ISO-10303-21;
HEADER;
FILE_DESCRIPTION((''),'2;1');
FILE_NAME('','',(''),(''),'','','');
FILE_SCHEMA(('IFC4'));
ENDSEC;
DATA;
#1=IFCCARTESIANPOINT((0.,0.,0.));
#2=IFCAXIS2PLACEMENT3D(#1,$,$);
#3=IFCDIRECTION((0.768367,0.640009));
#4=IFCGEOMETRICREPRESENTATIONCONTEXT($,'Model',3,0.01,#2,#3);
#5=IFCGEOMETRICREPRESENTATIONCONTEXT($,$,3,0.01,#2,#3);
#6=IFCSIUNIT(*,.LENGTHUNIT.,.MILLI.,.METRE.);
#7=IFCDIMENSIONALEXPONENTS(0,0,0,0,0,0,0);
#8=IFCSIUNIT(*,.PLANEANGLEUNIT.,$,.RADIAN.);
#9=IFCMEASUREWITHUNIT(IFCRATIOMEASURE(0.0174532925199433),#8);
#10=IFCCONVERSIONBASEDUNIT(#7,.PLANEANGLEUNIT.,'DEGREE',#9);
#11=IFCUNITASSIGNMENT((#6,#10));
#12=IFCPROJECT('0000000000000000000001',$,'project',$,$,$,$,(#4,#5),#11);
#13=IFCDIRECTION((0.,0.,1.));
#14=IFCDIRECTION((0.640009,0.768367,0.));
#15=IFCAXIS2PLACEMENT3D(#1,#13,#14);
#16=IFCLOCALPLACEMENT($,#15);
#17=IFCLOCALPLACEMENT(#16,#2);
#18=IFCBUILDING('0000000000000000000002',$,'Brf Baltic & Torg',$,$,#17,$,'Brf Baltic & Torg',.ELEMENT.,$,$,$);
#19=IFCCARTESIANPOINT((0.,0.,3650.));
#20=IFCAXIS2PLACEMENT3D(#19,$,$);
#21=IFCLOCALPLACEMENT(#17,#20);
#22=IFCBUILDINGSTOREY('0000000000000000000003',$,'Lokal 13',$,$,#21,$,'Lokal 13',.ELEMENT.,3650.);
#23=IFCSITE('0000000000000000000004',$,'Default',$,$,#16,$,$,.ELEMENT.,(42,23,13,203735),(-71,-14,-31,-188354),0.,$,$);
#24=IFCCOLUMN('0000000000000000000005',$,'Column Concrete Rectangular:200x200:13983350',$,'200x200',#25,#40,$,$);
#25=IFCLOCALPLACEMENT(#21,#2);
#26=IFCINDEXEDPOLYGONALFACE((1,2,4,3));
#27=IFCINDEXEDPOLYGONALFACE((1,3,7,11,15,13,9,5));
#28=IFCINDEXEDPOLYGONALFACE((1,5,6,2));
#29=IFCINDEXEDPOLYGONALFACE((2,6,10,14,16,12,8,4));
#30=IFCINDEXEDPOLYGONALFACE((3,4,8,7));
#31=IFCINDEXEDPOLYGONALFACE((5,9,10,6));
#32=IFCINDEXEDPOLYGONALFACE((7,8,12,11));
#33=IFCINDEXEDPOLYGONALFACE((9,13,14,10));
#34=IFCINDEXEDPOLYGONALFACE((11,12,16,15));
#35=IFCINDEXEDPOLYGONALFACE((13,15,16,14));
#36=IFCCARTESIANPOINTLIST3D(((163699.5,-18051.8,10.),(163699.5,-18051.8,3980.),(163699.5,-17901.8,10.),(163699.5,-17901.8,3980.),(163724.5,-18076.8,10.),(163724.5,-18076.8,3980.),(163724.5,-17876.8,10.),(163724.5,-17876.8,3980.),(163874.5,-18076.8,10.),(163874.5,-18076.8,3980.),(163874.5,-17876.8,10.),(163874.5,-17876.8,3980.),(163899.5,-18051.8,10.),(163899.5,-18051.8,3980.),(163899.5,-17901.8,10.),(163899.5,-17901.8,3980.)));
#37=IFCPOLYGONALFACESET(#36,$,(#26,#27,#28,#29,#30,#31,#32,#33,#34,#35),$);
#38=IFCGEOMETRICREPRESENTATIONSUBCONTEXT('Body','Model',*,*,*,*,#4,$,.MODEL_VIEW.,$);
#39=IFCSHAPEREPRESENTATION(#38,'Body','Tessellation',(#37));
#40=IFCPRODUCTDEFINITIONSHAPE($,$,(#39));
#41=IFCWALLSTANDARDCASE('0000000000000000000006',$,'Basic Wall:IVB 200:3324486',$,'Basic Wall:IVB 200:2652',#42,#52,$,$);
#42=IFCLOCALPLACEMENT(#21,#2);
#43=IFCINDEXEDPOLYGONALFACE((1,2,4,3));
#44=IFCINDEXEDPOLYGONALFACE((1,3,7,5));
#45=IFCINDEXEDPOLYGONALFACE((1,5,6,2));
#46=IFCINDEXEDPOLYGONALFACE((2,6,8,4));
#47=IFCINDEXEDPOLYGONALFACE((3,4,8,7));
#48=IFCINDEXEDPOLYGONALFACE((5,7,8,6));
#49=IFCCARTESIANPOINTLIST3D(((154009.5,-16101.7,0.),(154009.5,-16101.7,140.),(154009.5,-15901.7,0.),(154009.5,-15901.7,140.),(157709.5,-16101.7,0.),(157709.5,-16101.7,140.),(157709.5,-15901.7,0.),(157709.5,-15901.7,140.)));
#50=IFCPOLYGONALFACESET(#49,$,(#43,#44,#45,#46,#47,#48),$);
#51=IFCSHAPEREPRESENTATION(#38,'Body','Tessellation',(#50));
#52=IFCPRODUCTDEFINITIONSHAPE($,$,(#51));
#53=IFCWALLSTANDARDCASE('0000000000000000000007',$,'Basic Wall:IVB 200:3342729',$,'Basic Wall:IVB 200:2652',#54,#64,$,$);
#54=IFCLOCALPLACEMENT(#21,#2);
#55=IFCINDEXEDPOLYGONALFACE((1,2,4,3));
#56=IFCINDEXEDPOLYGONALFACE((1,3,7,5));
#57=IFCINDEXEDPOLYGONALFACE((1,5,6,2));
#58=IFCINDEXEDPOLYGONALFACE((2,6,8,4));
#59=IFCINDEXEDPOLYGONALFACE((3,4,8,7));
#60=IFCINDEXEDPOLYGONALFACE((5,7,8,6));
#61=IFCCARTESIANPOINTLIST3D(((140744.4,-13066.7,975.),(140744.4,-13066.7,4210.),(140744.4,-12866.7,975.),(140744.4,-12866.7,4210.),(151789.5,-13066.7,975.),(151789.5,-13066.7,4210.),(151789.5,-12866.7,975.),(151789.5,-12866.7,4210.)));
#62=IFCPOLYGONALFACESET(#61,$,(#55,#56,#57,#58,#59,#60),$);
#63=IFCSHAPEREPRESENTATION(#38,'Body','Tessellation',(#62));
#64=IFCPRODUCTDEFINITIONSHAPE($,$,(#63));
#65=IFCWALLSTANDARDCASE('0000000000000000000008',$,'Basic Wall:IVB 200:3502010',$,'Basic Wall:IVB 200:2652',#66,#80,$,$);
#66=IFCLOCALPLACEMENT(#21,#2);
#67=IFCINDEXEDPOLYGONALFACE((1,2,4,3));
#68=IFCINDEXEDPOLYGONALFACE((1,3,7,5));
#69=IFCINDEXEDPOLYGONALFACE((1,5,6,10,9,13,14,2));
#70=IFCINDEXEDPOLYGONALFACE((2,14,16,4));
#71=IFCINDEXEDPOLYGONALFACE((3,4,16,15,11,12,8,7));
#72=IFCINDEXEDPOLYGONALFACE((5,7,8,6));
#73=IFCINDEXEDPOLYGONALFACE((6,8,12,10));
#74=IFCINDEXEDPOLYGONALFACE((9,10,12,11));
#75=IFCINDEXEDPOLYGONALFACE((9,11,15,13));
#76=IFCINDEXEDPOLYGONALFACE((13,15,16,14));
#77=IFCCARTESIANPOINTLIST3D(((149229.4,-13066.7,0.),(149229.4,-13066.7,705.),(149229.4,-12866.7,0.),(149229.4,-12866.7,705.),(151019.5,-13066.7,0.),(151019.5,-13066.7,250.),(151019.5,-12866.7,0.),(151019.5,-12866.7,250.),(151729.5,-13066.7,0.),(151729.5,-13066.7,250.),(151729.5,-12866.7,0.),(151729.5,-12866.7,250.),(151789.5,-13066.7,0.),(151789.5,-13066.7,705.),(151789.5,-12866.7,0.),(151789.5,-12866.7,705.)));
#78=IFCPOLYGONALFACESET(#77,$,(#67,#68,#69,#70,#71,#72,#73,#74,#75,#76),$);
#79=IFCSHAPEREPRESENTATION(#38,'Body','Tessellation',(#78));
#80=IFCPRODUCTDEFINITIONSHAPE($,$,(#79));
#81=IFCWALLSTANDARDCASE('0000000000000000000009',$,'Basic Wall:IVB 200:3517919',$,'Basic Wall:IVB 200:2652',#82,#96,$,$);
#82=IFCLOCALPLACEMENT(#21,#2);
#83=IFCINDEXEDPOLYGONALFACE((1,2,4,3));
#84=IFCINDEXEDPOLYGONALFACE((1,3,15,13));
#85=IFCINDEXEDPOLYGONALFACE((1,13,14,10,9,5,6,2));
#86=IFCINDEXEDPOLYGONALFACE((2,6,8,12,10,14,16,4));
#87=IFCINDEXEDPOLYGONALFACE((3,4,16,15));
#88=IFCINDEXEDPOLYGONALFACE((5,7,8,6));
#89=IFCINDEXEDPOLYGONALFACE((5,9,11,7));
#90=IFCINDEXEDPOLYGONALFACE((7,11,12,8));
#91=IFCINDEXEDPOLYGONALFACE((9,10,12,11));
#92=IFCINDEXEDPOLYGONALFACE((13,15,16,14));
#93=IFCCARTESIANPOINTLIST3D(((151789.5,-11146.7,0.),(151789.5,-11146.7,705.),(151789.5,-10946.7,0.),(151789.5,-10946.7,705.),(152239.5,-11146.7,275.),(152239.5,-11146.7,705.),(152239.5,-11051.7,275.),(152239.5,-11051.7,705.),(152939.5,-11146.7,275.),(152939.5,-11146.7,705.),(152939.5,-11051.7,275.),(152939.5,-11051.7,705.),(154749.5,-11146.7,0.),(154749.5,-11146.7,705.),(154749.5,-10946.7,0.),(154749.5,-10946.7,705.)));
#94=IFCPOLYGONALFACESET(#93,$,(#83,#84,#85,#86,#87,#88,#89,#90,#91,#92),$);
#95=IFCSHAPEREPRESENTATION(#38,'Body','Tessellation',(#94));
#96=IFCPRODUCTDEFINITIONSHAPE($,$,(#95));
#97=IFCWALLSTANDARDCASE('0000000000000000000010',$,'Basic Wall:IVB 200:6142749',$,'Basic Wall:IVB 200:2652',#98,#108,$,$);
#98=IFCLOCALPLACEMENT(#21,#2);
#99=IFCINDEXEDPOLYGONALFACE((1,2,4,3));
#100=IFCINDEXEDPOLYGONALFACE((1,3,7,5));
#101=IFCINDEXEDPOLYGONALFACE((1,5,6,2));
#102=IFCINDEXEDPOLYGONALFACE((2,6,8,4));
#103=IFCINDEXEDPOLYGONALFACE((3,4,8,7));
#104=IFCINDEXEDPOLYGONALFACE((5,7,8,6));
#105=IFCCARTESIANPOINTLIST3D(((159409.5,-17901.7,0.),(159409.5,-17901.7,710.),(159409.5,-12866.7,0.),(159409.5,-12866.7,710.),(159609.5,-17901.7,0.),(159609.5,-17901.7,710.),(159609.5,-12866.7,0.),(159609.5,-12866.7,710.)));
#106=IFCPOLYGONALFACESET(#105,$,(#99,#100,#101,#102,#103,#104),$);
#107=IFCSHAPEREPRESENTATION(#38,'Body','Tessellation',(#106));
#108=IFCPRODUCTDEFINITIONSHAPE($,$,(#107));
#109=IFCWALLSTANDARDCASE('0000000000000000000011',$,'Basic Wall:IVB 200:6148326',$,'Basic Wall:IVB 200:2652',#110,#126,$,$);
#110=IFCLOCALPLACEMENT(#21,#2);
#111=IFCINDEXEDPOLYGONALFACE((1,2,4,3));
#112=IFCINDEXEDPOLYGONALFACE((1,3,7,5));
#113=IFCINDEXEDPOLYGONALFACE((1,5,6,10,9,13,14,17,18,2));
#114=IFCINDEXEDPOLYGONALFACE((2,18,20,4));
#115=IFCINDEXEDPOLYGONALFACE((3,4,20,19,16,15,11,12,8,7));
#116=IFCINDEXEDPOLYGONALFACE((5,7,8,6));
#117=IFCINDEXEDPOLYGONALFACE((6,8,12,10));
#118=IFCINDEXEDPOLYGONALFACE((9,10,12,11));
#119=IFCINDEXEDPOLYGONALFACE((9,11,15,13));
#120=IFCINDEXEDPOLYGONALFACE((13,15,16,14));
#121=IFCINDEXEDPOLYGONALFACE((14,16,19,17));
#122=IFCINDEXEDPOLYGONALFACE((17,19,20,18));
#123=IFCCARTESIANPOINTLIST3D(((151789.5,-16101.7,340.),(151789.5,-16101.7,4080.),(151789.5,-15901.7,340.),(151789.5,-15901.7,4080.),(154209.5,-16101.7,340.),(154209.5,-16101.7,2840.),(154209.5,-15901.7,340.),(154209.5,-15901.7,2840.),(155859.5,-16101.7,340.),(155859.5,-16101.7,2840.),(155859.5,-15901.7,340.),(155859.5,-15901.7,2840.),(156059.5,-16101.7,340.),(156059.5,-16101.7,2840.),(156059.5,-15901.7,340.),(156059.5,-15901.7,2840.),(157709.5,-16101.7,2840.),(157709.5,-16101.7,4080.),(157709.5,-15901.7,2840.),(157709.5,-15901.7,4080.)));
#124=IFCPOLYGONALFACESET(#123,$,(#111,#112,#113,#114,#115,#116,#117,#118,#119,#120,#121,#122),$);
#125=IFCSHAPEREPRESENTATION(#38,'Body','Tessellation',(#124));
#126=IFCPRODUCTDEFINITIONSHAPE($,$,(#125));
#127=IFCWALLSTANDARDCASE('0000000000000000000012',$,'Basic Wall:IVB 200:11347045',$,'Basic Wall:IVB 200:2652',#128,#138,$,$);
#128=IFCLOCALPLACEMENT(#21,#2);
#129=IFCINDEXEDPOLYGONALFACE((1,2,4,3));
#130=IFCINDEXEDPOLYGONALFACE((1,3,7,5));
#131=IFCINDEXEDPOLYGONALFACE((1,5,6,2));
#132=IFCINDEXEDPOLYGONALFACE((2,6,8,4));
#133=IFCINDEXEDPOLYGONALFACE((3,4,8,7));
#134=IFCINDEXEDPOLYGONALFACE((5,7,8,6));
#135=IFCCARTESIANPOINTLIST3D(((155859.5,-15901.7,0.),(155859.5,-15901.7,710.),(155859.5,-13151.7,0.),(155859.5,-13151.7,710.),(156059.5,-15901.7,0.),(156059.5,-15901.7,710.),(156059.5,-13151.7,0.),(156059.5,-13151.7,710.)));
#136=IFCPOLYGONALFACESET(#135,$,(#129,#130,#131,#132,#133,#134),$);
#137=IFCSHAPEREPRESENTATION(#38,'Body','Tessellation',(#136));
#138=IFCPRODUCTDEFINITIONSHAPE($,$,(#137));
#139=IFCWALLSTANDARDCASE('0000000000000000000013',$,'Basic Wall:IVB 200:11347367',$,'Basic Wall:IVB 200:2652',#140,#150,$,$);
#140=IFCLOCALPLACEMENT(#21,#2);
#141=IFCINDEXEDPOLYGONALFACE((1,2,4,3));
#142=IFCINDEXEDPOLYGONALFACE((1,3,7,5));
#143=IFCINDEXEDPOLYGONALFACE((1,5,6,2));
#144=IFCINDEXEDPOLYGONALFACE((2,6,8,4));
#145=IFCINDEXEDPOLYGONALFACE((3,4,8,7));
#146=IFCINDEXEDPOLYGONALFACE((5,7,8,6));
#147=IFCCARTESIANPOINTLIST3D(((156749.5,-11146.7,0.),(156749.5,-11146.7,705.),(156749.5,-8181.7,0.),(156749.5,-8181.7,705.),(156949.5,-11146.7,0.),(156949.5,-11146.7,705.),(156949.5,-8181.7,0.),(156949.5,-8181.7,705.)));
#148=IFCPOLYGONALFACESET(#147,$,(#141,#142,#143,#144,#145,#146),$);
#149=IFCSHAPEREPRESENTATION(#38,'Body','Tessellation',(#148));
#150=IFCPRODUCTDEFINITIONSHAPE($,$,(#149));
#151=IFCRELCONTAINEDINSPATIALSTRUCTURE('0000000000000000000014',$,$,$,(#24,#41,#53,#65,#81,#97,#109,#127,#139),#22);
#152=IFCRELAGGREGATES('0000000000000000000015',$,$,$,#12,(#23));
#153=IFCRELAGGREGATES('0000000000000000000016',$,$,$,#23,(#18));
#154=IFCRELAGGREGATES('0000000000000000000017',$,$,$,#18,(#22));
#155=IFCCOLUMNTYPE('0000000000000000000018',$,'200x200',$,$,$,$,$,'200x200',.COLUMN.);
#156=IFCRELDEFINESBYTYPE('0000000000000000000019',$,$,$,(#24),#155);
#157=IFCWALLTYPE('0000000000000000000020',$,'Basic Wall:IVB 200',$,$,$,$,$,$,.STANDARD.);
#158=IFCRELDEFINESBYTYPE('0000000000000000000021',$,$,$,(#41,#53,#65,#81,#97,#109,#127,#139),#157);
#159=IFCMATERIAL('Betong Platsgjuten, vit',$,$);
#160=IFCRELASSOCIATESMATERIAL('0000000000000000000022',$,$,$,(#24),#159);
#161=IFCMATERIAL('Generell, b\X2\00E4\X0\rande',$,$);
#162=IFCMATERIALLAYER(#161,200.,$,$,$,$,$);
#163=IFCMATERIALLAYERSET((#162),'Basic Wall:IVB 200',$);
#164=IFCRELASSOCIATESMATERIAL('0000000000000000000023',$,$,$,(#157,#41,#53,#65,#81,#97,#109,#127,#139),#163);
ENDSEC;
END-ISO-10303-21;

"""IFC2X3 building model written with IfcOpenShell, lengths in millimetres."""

from ifc_helpers import new_model, entity, si_unit, converted_unit, direction, frame, frame_2d, origin, place, context, subcontext, project, spatial, polyline, rectangle, outline, extrude, clip, halfspace, bounded_halfspace, source, transform, mapped, material, layer, layer_set, layer_usage, type_object, type_shapes, element, save


model = new_model("IFC2X3")

# Units and contexts
model_context = context("Model", 3, precision=0.01, world=origin(), true_north=direction((0.768367, 0.640009)))
context_of_model = context(None, 3, precision=0.01, world=origin(), true_north=direction((0.768367, 0.640009)))
body_context = subcontext(model_context, "Body", "Model", "MODEL_VIEW")
ifc_project = project(units=[si_unit("LENGTHUNIT", "METRE", prefix="MILLI"), converted_unit("PLANEANGLEUNIT", "DEGREE", entity("IfcRatioMeasure", 0.0174532925199433), si_unit("PLANEANGLEUNIT", "RADIAN"), dimensions=[0, 0, 0, 0, 0, 0, 0])], contexts=[model_context, context_of_model])

# Site, building, storey
site_placement = place(None, frame((0.0, 0.0, 0.0), z_axis=(0.0, 0.0, 1.0), x_axis=(0.640009, 0.768367, 0.0)))
site = spatial("IfcSite", under=ifc_project, at=site_placement, Name="Default", CompositionType="ELEMENT", RefLatitude=(42, 23, 13, 203735), RefLongitude=(-71, -14, -31, -188354), RefElevation=0.0)
building_placement = place(site_placement, origin())
building = spatial("IfcBuilding", under=site, at=building_placement, Name="Brf Baltic & Torg", LongName="Brf Baltic & Torg", CompositionType="ELEMENT")
storey_placement = place(building_placement, frame((0.0, 0.0, 3650.0)))
storey = spatial("IfcBuildingStorey", under=building, at=storey_placement, Name="Lokal 13", LongName="Lokal 13", CompositionType="ELEMENT", Elevation=3650.0)

# Column
ifc_material_1 = material(Name="Betong Platsgjuten, vit")
column_type = type_object("IfcColumnType", Name="200x200", ElementType="200x200", PredefinedType="COLUMN")
shared_shape = source(origin(), body_context, "Body", "SweptSolid", [
    extrude(outline(polyline([(-75.0, -100.0), (75.0, -100.0), (100.0, -75.0), (100.0, 75.0), (75.0, 100.0), (-75.0, 100.0), (-100.0, 75.0), (-100.0, -75.0), (-75.0, -100.0)])), frame((0.0, 0.0, 3660.0), z_axis=(0.0, 0.0, 1.0), x_axis=(0.0, -1.0, 0.0)), (0.0, 0.0, 1.0), 3970.0),
])
type_shapes(column_type, [shared_shape])
column_placement = place(storey_placement, frame((163799.5, -17976.8, -3650.0)))
element("IfcColumn", 1, at=column_placement, inside=storey, type_object=column_type, material=ifc_material_1, Name="Column Concrete Rectangular:200x200:13983350", ObjectType="200x200", context=body_context, shape_type="MappedRepresentation", body=[
    mapped(shared_shape, transform((0.0, 0.0, 0.0), scale=1.0)),
])

# Wall
ifc_material_2 = material(Name="Generell, bärande")
ifc_layer = layer(ifc_material_2, 200.0)
ifc_layer_set = layer_set([ifc_layer], Name="Basic Wall:IVB 200")
ifc_layer_usage_1 = layer_usage(ifc_layer_set, "AXIS2", "NEGATIVE", 100.0)
wall_type = type_object("IfcWallType", Name="Basic Wall:IVB 200", PredefinedType="STANDARD", material=ifc_layer_set)
wall_1_placement = place(storey_placement, frame((157709.5, -16001.7, 0.0), z_axis=(0.0, 0.0, 1.0), x_axis=(-1.0, 0.0, 0.0)))
element("IfcWallStandardCase", 2, at=wall_1_placement, inside=storey, type_object=wall_type, material=ifc_layer_usage_1, Name="Basic Wall:IVB 200:3324486", ObjectType="Basic Wall:IVB 200:2652", context=body_context, shape_type="Clipping", body=[
    clip(clip(extrude(rectangle(XDim=3700.0, YDim=200.0, at=frame_2d((1850.0, 0.0), x_axis=(-1.0, 0.0))), origin(), (0.0, 0.0, 1.0), 140.0), bounded_halfspace(frame((0.0, -100.0, 140.0), z_axis=(0.0, 0.0, -1.0), x_axis=(0.0, -1.0, 0.0)), True, frame((0.0, -100.0, 140.0)), polyline([(0.0, 0.0), (3700.0, 0.0), (3700.0, 200.0), (0.0, 200.0), (0.0, 0.0)]))), halfspace(frame((0.0, 0.0, -2000.0)), True)),
])

# Wall
ifc_layer_usage_2 = layer_usage(ifc_layer_set, "AXIS2", "NEGATIVE", 100.0)
wall_2_placement = place(storey_placement, frame((151789.5, -12966.7, 975.0), z_axis=(0.0, 0.0, 1.0), x_axis=(-1.0, 0.0, 0.0)))
element("IfcWallStandardCase", 3, at=wall_2_placement, inside=storey, type_object=wall_type, material=ifc_layer_usage_2, Name="Basic Wall:IVB 200:3342729", ObjectType="Basic Wall:IVB 200:2652", context=body_context, shape_type="SweptSolid", body=[
    extrude(rectangle(XDim=11045.1, YDim=200.0, at=frame_2d((5522.5, 0.0), x_axis=(-1.0, 0.0))), origin(), (0.0, 0.0, 1.0), 3235.0),
])

# Walls, openings
ifc_layer_usage_3 = layer_usage(ifc_layer_set, "AXIS2", "NEGATIVE", 100.0)
wall_3_placement = place(storey_placement, frame((151789.5, -12966.7, 0.0), z_axis=(0.0, 0.0, 1.0), x_axis=(-1.0, 0.0, 0.0)))
wall_3 = element("IfcWallStandardCase", 4, at=wall_3_placement, inside=storey, type_object=wall_type, material=ifc_layer_usage_3, Name="Basic Wall:IVB 200:3502010", ObjectType="Basic Wall:IVB 200:2652", context=body_context, shape_type="Clipping", body=[
    clip(clip(extrude(rectangle(XDim=2560.1, YDim=200.0, at=frame_2d((1280.0, 0.0), x_axis=(-1.0, 0.0))), origin(), (0.0, 0.0, 1.0), 705.0), bounded_halfspace(frame((0.0, -100.0, 705.0), z_axis=(0.0, 0.0, -1.0), x_axis=(0.0, -1.0, 0.0)), True, frame((0.0, -100.0, 705.0)), polyline([(0.0, 0.0), (2560.1, 0.0), (2560.1, 200.0), (0.0, 200.0), (0.0, 0.0)]))), halfspace(frame((0.0, 0.0, -2000.0)), True)),
])
opening_1_placement = place(wall_3_placement, frame((151789.5, -12966.7, -2000.0), z_axis=(0.0, 0.0, 1.0), x_axis=(-1.0, 0.0, 0.0)))
element("IfcOpeningElement", 5, at=opening_1_placement, cuts=wall_3, ObjectType="Opening", context=body_context, shape_type="SweptSolid", body=[
    extrude(rectangle(XDim=910.0, YDim=710.0, at=frame_2d((0.0, 0.0), x_axis=(0.0, 1.0))), frame((151374.5, -11542.7, 1795.0), z_axis=(0.0, -1.0, 0.0), x_axis=(1.0, 0.0, 0.0)), (0.0, 0.0, 1.0), 3048.0),
])
ifc_layer_usage_4 = layer_usage(ifc_layer_set, "AXIS2", "NEGATIVE", 100.0)
wall_4_placement = place(storey_placement, frame((151789.5, -11046.7, 0.0)))
wall_4 = element("IfcWallStandardCase", 6, at=wall_4_placement, inside=storey, type_object=wall_type, material=ifc_layer_usage_4, Name="Basic Wall:IVB 200:3517919", ObjectType="Basic Wall:IVB 200:2652", context=body_context, shape_type="Clipping", body=[
    clip(clip(extrude(rectangle(XDim=2960.0, YDim=200.0, at=frame_2d((1480.0, 0.0), x_axis=(-1.0, 0.0))), origin(), (0.0, 0.0, 1.0), 705.0), bounded_halfspace(frame((0.0, 100.0, 705.0), z_axis=(0.0, 0.0, -1.0), x_axis=(0.0, 1.0, 0.0)), True, frame((0.0, 100.0, 705.0)), polyline([(0.0, 0.0), (0.0, -200.0), (200.0, -200.0), (450.0, -200.0), (450.0, -105.0), (950.0, -105.0), (950.0, 0.0), (760.0, 0.0), (0.0, 0.0)]))), halfspace(frame((0.0, 0.0, -2000.0)), True)),
])
opening_2_placement = place(wall_4_placement, origin())
element("IfcOpeningElement", 7, at=opening_2_placement, cuts=wall_4, ObjectType="Recess", context=body_context, shape_type="SweptSolid", body=[
    extrude(rectangle(XDim=430.0, YDim=700.0, at=frame_2d((0.0, 0.0), x_axis=(1.0, 0.0))), frame((800.0, -100.0, 490.0), z_axis=(0.0, 1.0, 0.0), x_axis=(0.0, 0.0, -1.0)), (0.0, 0.0, 1.0), 95.0),
])

# Wall
ifc_layer_usage_5 = layer_usage(ifc_layer_set, "AXIS2", "POSITIVE", -100.0)
wall_5_placement = place(storey_placement, frame((159509.5, -12866.7, 0.0), z_axis=(0.0, 0.0, 1.0), x_axis=(0.0, -1.0, 0.0)))
element("IfcWallStandardCase", 8, at=wall_5_placement, inside=storey, type_object=wall_type, material=ifc_layer_usage_5, Name="Basic Wall:IVB 200:6142749", ObjectType="Basic Wall:IVB 200:2652", context=body_context, shape_type="Clipping", body=[
    clip(extrude(rectangle(XDim=5035.0, YDim=200.0, at=frame_2d((2517.5, 0.0), x_axis=(-1.0, 0.0))), origin(), (0.0, 0.0, 1.0), 710.0), halfspace(frame((0.0, 0.0, -2000.0)), True)),
])

# Wall, openings
ifc_layer_usage_6 = layer_usage(ifc_layer_set, "AXIS2", "NEGATIVE", 100.0)
wall_6_placement = place(storey_placement, frame((157709.5, -16001.7, 340.0), z_axis=(0.0, 0.0, 1.0), x_axis=(-1.0, 0.0, 0.0)))
wall_6 = element("IfcWallStandardCase", 9, at=wall_6_placement, inside=storey, type_object=wall_type, material=ifc_layer_usage_6, Name="Basic Wall:IVB 200:6148326", ObjectType="Basic Wall:IVB 200:2652", context=body_context, shape_type="SweptSolid", body=[
    extrude(rectangle(XDim=5920.0, YDim=200.0, at=frame_2d((2960.0, 0.0), x_axis=(-1.0, 0.0))), origin(), (0.0, 0.0, 1.0), 3740.0),
])
opening_3_placement = place(wall_6_placement, frame((157709.5, -16001.7, -340.0), z_axis=(0.0, 0.0, 1.0), x_axis=(-1.0, 0.0, 0.0)))
element("IfcOpeningElement", 10, at=opening_3_placement, cuts=wall_6, ObjectType="Opening", context=body_context, shape_type="SweptSolid", body=[
    extrude(rectangle(XDim=2500.0, YDim=1650.0, at=frame_2d((0.0, 0.0), x_axis=(0.0, 1.0))), frame((155034.5, -14377.7, 1590.0), z_axis=(0.0, -1.0, 0.0), x_axis=(1.0, 0.0, 0.0)), (0.0, 0.0, 1.0), 3048.0),
])
opening_4_placement = place(wall_6_placement, frame((157709.5, -16001.7, -340.0), z_axis=(0.0, 0.0, 1.0), x_axis=(-1.0, 0.0, 0.0)))
element("IfcOpeningElement", 11, at=opening_4_placement, cuts=wall_6, ObjectType="Opening", context=body_context, shape_type="SweptSolid", body=[
    extrude(rectangle(XDim=2500.0, YDim=1650.0, at=frame_2d((0.0, 0.0), x_axis=(0.0, 1.0))), frame((156884.5, -14377.7, 1590.0), z_axis=(0.0, -1.0, 0.0), x_axis=(1.0, 0.0, 0.0)), (0.0, 0.0, 1.0), 3048.0),
])

# Walls
ifc_layer_usage_7 = layer_usage(ifc_layer_set, "AXIS2", "NEGATIVE", 100.0)
wall_7_placement = place(storey_placement, frame((155959.5, -15901.7, 0.0), z_axis=(0.0, 0.0, 1.0), x_axis=(0.0, 1.0, 0.0)))
element("IfcWallStandardCase", 12, at=wall_7_placement, inside=storey, type_object=wall_type, material=ifc_layer_usage_7, Name="Basic Wall:IVB 200:11347045", ObjectType="Basic Wall:IVB 200:2652", context=body_context, shape_type="Clipping", body=[
    clip(extrude(rectangle(XDim=2750.0, YDim=200.0, at=frame_2d((1375.0, 0.0), x_axis=(-1.0, 0.0))), origin(), (0.0, 0.0, 1.0), 710.0), halfspace(frame((0.0, 0.0, -2000.0)), True)),
])
ifc_layer_usage_8 = layer_usage(ifc_layer_set, "AXIS2", "POSITIVE", -100.0)
wall_8_placement = place(storey_placement, frame((156849.5, -8181.7, 0.0), z_axis=(0.0, 0.0, 1.0), x_axis=(0.0, -1.0, 0.0)))
element("IfcWallStandardCase", 13, at=wall_8_placement, inside=storey, type_object=wall_type, material=ifc_layer_usage_8, Name="Basic Wall:IVB 200:11347367", ObjectType="Basic Wall:IVB 200:2652", context=body_context, shape_type="Clipping", body=[
    clip(clip(extrude(rectangle(XDim=2965.0, YDim=200.0, at=frame_2d((1482.5, 0.0), x_axis=(-1.0, 0.0))), origin(), (0.0, 0.0, 1.0), 705.0), bounded_halfspace(frame((0.0, -100.0, 705.0), z_axis=(0.0, 0.0, -1.0), x_axis=(-1.0, 0.0, 0.0)), True, frame((0.0, -100.0, 705.0)), polyline([(0.0, 0.0), (200.0, 0.0), (2965.0, 0.0), (2965.0, 200.0), (2765.0, 200.0), (200.0, 200.0), (0.0, 200.0), (0.0, 0.0)]))), halfspace(frame((0.0, 0.0, -2000.0)), True)),
])

save(model, "model.ifc")
